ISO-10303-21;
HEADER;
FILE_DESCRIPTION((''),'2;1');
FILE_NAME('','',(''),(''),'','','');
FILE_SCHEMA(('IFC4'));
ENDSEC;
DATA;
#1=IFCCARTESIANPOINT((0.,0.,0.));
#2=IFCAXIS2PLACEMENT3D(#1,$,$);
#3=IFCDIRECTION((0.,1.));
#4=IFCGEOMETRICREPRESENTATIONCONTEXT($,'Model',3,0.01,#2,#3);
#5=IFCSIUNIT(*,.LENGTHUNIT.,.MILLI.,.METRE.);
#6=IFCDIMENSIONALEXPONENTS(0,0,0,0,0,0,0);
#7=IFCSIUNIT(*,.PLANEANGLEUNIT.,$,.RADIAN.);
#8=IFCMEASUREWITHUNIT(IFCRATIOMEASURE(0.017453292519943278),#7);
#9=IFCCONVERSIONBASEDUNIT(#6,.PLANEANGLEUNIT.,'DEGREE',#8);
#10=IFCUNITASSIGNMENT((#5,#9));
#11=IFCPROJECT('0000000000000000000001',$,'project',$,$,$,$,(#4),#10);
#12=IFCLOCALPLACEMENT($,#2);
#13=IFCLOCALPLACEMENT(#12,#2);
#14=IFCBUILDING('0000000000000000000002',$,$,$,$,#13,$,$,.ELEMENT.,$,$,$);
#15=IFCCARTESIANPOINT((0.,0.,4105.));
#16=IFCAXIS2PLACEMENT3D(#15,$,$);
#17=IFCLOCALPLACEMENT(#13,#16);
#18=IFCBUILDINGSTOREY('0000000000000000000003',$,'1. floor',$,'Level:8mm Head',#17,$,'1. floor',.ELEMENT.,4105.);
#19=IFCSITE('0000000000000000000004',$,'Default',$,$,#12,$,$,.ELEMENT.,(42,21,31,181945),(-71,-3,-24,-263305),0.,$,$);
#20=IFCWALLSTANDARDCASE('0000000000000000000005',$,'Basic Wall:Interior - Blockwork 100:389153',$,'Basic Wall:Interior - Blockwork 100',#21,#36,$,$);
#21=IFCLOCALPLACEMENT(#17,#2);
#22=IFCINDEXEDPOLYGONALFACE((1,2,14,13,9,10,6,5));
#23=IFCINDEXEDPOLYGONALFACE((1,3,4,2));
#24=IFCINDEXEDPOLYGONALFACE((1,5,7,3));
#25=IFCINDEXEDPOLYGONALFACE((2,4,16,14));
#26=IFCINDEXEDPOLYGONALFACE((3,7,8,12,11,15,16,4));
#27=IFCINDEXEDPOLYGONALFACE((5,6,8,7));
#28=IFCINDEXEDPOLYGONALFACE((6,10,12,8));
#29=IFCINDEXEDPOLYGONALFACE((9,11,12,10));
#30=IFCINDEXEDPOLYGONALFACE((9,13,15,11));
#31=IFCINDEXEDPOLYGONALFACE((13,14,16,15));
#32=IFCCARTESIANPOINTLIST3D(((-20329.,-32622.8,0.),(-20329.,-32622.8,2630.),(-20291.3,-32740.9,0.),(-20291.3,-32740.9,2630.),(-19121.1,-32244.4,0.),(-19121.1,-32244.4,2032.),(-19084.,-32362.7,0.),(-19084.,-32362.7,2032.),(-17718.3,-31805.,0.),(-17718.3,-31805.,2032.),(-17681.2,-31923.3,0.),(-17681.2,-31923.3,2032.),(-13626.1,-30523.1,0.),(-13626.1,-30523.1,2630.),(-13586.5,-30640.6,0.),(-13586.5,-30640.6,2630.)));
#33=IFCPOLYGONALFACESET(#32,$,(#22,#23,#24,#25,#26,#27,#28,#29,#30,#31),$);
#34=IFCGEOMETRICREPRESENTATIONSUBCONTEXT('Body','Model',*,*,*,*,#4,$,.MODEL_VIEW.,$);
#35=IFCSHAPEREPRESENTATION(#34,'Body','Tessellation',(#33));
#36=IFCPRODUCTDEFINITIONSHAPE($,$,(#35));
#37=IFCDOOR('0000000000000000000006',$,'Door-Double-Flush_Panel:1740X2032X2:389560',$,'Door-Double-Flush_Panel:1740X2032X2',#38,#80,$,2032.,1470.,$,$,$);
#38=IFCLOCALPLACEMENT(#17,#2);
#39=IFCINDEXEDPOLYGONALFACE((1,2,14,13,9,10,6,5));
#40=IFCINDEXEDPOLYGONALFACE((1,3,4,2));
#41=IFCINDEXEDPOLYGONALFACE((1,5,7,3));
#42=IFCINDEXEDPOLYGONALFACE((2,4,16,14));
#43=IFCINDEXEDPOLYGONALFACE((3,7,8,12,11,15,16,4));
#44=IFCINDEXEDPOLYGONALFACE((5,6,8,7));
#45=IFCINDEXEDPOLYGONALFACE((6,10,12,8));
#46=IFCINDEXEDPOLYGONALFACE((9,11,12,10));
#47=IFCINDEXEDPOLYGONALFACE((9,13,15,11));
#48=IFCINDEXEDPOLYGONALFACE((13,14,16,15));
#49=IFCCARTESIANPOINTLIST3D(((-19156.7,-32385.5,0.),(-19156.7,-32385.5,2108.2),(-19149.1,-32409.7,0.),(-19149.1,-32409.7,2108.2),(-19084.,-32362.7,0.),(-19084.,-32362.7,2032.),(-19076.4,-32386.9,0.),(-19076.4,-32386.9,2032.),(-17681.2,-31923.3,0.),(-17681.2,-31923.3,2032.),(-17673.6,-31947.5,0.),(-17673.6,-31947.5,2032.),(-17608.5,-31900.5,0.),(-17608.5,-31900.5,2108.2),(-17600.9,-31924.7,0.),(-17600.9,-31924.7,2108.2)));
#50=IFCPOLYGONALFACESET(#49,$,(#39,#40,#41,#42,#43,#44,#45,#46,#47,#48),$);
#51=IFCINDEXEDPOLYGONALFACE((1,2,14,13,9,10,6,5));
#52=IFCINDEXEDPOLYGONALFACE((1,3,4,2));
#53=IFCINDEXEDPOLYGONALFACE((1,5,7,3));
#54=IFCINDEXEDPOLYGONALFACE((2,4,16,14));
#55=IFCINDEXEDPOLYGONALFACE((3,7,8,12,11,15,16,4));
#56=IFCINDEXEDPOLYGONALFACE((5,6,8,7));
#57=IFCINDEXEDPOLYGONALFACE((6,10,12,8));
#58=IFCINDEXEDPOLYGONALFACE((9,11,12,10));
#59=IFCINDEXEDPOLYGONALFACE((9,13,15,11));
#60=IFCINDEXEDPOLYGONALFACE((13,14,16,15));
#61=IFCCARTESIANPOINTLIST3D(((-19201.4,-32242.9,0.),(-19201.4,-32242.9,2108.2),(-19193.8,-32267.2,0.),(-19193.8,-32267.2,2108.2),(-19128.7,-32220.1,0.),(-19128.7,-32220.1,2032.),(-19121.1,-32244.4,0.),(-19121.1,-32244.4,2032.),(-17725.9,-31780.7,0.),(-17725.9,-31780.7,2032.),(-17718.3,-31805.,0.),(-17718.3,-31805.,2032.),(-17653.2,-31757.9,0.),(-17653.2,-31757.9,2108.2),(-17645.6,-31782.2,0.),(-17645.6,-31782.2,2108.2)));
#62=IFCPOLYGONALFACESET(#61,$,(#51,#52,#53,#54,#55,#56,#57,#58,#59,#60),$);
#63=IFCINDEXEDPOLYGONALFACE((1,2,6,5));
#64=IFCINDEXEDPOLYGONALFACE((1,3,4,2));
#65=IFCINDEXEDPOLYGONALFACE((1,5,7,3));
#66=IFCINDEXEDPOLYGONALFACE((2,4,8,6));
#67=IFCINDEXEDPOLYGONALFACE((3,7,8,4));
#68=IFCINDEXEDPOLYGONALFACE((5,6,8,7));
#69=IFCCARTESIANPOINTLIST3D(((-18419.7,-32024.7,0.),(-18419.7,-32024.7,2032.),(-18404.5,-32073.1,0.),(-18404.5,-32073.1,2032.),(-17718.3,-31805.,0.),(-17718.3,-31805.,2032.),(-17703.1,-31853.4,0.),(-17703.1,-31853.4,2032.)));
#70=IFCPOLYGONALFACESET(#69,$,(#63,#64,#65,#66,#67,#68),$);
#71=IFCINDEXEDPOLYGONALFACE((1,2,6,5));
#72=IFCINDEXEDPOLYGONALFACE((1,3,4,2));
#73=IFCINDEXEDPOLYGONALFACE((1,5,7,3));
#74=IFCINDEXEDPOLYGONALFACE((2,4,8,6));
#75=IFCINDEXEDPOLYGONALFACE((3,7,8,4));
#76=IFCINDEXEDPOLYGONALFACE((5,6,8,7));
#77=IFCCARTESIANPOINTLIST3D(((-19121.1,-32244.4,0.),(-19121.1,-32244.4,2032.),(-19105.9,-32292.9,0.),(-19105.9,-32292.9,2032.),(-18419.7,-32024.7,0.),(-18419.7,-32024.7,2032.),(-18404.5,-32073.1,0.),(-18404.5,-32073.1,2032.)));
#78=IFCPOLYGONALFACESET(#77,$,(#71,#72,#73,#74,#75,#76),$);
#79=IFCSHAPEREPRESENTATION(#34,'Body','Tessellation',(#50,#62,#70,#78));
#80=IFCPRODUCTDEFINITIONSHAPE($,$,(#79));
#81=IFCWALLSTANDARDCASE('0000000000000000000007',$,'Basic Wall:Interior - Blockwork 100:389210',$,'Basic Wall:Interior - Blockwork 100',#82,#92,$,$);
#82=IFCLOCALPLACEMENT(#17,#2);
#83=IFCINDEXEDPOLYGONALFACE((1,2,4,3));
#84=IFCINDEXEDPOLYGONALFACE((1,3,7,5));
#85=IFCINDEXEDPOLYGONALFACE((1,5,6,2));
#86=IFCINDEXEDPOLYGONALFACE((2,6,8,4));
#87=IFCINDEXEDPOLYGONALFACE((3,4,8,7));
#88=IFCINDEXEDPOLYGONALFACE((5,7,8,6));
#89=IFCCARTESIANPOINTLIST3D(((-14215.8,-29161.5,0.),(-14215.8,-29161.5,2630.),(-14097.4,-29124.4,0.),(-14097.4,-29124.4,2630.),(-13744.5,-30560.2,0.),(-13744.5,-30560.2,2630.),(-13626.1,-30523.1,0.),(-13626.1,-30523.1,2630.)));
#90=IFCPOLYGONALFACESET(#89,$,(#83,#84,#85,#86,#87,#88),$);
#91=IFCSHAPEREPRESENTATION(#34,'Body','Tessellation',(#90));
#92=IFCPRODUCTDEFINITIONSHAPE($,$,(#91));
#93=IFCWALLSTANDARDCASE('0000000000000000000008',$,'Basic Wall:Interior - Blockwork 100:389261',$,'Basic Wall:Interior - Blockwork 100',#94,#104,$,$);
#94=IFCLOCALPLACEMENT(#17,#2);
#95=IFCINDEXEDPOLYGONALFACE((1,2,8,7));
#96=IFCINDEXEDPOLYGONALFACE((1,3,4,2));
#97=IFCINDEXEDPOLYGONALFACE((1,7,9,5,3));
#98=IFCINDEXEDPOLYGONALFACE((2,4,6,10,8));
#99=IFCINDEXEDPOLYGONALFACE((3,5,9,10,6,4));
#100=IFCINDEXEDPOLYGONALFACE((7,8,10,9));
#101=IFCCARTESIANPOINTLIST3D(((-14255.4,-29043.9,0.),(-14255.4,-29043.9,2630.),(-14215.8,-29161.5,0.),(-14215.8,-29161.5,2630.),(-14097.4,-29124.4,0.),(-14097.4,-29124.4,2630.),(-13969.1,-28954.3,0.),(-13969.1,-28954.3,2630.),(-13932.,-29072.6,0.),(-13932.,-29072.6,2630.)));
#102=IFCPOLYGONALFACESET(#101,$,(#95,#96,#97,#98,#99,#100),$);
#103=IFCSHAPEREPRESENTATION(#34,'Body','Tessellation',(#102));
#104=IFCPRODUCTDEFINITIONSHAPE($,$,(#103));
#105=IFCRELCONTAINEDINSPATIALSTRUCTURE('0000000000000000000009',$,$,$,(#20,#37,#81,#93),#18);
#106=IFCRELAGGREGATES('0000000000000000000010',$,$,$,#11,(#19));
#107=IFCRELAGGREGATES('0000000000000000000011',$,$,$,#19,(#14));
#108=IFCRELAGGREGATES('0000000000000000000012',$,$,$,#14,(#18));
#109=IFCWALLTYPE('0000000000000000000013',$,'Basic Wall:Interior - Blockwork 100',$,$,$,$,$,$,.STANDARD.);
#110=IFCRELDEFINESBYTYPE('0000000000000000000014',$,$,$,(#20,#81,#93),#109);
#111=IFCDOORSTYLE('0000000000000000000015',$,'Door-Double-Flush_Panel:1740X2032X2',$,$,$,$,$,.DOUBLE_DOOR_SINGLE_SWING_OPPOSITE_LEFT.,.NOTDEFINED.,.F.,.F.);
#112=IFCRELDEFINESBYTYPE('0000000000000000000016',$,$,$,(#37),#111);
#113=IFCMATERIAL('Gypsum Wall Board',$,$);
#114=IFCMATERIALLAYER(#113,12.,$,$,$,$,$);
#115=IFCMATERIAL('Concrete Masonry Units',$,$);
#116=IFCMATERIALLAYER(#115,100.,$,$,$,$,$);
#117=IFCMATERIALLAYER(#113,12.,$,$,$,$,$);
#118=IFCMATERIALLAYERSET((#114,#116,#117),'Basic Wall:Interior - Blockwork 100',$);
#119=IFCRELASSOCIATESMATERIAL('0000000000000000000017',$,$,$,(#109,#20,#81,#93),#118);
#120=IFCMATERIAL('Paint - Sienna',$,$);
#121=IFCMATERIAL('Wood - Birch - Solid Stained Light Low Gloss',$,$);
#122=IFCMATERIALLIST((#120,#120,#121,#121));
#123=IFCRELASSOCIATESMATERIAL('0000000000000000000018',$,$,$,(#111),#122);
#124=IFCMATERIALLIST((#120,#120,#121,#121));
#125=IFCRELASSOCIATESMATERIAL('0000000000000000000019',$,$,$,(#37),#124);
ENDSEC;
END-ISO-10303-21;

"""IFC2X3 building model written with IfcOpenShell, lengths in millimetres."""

from ifc_helpers import new_model, entity, si_unit, converted_unit, direction, frame, frame_2d, origin, origin_2d_with_axis, place, context, subcontext, project, spatial, polyline, rectangle, outline, extrude, source, transform, mapped, material, material_list, layer, layer_set, layer_usage, type_object, type_shapes, element, fill, save


model = new_model("IFC2X3")

# Units and contexts
model_context = context("Model", 3, precision=0.01, world=origin(), true_north=direction((0.0, 1.0)))
body_context = subcontext(model_context, "Body", "Model", "MODEL_VIEW")
ifc_project = project(units=[si_unit("LENGTHUNIT", "METRE", prefix="MILLI"), converted_unit("PLANEANGLEUNIT", "DEGREE", entity("IfcRatioMeasure", 0.017453292519943278), si_unit("PLANEANGLEUNIT", "RADIAN"), dimensions=[0, 0, 0, 0, 0, 0, 0])], contexts=[model_context])

# Site, building, storey
site_placement = place(None, origin())
site = spatial("IfcSite", under=ifc_project, at=site_placement, Name="Default", CompositionType="ELEMENT", RefLatitude=(42, 21, 31, 181945), RefLongitude=(-71, -3, -24, -263305), RefElevation=0.0)
building_placement = place(site_placement, origin())
building = spatial("IfcBuilding", under=site, at=building_placement, CompositionType="ELEMENT")
storey_placement = place(building_placement, frame((0.0, 0.0, 4105.0)))
storey = spatial("IfcBuildingStorey", under=building, at=storey_placement, Name="1. floor", ObjectType="Level:8mm Head", LongName="1. floor", CompositionType="ELEMENT", Elevation=4105.0)

# Shared definitions
ifc_material_1 = material(Name="Gypsum Wall Board")
ifc_material_2 = material(Name="Paint - Sienna")
ifc_material_3 = material(Name="Wood - Birch - Solid Stained Light Low Gloss")

# Shared definitions
ifc_layer_1 = layer(ifc_material_1, 12.0)
ifc_material_4 = material(Name="Concrete Masonry Units")
ifc_layer_2 = layer(ifc_material_4, 100.0)
ifc_layer_3 = layer(ifc_material_1, 12.0)
ifc_layer_set_1 = layer_set([ifc_layer_1, ifc_layer_2, ifc_layer_3], Name="Basic Wall:Interior - Blockwork 100")
wall_type_1 = type_object("IfcWallType", Name="Basic Wall:Interior - Blockwork 100", PredefinedType="STANDARD", material=ifc_layer_set_1)

# Wall, opening, door
ifc_layer_usage_1 = layer_usage(ifc_layer_set_1, "AXIS2", "NEGATIVE", 62.0)
wall_1_placement = place(storey_placement, frame((-20310.5, -32681.9, 0.0), z_axis=(0.0, 0.0, 1.0), x_axis=(0.954277, 0.298924, 0.0)))
wall_1 = element("IfcWallStandardCase", 1, at=wall_1_placement, inside=storey, type_object=wall_type_1, material=ifc_layer_usage_1, Name="Basic Wall:Interior - Blockwork 100:389153", ObjectType="Basic Wall:Interior - Blockwork 100", context=body_context, shape_type="SweptSolid", body=[
    extrude(outline(polyline([(0.6, -62.0), (7026.7, -62.0), (7024.0, 62.0), (6900.0, 62.0), (0.0, 62.0), (0.6, -62.0)])), origin(), (0.0, 0.0, 1.0), 2630.0),
])
opening_1_placement = place(wall_1_placement, frame((1265.8, -62.0, 0.0)))
opening_1 = element("IfcOpeningElement", 2, at=opening_1_placement, cuts=wall_1, ObjectType="Opening", context=body_context, shape_type="SweptSolid", body=[
    extrude(rectangle(XDim=2032.0, YDim=1470.0, at=frame_2d((1016.0, 735.0), x_axis=(1.0, 0.0))), frame((0.0, 0.0, 0.0), z_axis=(0.0, 1.0, 0.0), x_axis=(0.0, 0.0, 1.0)), (0.0, 0.0, 1.0), 124.0),
])
ifc_material_list_1 = material_list([ifc_material_2, ifc_material_2, ifc_material_3, ifc_material_3])
ifc_material_list_2 = material_list([ifc_material_2, ifc_material_2, ifc_material_3, ifc_material_3])
door_style_1 = type_object("IfcDoorStyle", Name="Door-Double-Flush_Panel:1740X2032X2", ConstructionType="NOTDEFINED", OperationType="DOUBLE_DOOR_SINGLE_SWING_OPPOSITE_LEFT", ParameterTakesPrecedence=False, Sizeable=False, material=ifc_material_list_2)
shared_shape_1 = source(origin(), body_context, "Body", "SweptSolid", [
    extrude(outline(polyline([(-996.9, 735.0), (1035.0, 735.0), (1035.0, 811.2), (-1073.1, 811.2), (-1073.1, -811.2), (1035.0, -811.2), (1035.0, -735.0), (-996.9, -735.0), (-996.9, 735.0)])), frame((735.0, -25.4, 1035.0), z_axis=(0.0, 1.0, 0.0), x_axis=(0.0, 0.0, -1.0)), (0.0, 0.0, 1.0), 25.4),
    extrude(outline(polyline([(-996.9, 735.0), (1035.0, 735.0), (1035.0, 811.2), (-1073.1, 811.2), (-1073.1, -811.2), (1035.0, -811.2), (1035.0, -735.0), (-996.9, -735.0), (-996.9, 735.0)])), frame((735.0, 124.0, 1035.0), z_axis=(0.0, 1.0, 0.0), x_axis=(0.0, 0.0, -1.0)), (0.0, 0.0, 1.0), 25.4),
    extrude(rectangle(XDim=50.8, YDim=735.0, at=frame_2d((0.0, 0.0), x_axis=(1.0, 0.0))), frame((1102.5, 98.6, 0.0), z_axis=(0.0, 0.0, 1.0), x_axis=(0.0, -1.0, 0.0)), (0.0, 0.0, 1.0), 2032.0),
    extrude(rectangle(XDim=50.8, YDim=735.0, at=origin_2d_with_axis()), frame((367.5, 98.6, 0.0), z_axis=(0.0, 0.0, 1.0), x_axis=(0.0, -1.0, 0.0)), (0.0, 0.0, 1.0), 2032.0),
])
type_shapes(door_style_1, [shared_shape_1])
door_1_placement = place(opening_1_placement, origin())
door_1 = element("IfcDoor", 3, at=door_1_placement, inside=storey, type_object=door_style_1, material=ifc_material_list_1, Name="Door-Double-Flush_Panel:1740X2032X2:389560", ObjectType="Door-Double-Flush_Panel:1740X2032X2", OverallHeight=2032.0, OverallWidth=1470.0, context=body_context, shape_type="MappedRepresentation", body=[
    mapped(shared_shape_1, transform((0.0, 0.0, 0.0), scale=1.0)),
])
fill(opening_1, door_1)

# Walls
ifc_layer_usage_2 = layer_usage(ifc_layer_set_1, "AXIS2", "NEGATIVE", 62.0)
wall_2_placement = place(storey_placement, frame((-13684.9, -30542.9, 0.0), z_axis=(0.0, 0.0, 1.0), x_axis=(-0.319293, 0.947656, 0.0)))
element("IfcWallStandardCase", 4, at=wall_2_placement, inside=storey, type_object=wall_type_1, material=ifc_layer_usage_2, Name="Basic Wall:Interior - Blockwork 100:389210", ObjectType="Basic Wall:Interior - Blockwork 100", context=body_context, shape_type="SweptSolid", body=[
    extrude(outline(polyline([(1476.0, -62.0), (1478.6, 62.0), (2.7, 62.0), (0.0, -62.0), (1476.0, -62.0)])), origin(), (0.0, 0.0, 1.0), 2630.0),
])
ifc_layer_usage_3 = layer_usage(ifc_layer_set_1, "AXIS2", "NEGATIVE", 62.0)
wall_3_placement = place(storey_placement, frame((-14236.8, -29103.1, 0.0), z_axis=(0.0, 0.0, 1.0), x_axis=(0.954277, 0.298924, 0.0)))
element("IfcWallStandardCase", 5, at=wall_3_placement, inside=storey, type_object=wall_type_1, material=ifc_layer_usage_3, Name="Basic Wall:Interior - Blockwork 100:389261", ObjectType="Basic Wall:Interior - Blockwork 100", context=body_context, shape_type="SweptSolid", body=[
    extrude(outline(polyline([(300.0, -62.0), (300.0, 62.0), (0.0, 62.0), (2.7, -62.0), (126.7, -62.0), (300.0, -62.0)])), origin(), (0.0, 0.0, 1.0), 2630.0),
])

save(model, "model.ifc")
